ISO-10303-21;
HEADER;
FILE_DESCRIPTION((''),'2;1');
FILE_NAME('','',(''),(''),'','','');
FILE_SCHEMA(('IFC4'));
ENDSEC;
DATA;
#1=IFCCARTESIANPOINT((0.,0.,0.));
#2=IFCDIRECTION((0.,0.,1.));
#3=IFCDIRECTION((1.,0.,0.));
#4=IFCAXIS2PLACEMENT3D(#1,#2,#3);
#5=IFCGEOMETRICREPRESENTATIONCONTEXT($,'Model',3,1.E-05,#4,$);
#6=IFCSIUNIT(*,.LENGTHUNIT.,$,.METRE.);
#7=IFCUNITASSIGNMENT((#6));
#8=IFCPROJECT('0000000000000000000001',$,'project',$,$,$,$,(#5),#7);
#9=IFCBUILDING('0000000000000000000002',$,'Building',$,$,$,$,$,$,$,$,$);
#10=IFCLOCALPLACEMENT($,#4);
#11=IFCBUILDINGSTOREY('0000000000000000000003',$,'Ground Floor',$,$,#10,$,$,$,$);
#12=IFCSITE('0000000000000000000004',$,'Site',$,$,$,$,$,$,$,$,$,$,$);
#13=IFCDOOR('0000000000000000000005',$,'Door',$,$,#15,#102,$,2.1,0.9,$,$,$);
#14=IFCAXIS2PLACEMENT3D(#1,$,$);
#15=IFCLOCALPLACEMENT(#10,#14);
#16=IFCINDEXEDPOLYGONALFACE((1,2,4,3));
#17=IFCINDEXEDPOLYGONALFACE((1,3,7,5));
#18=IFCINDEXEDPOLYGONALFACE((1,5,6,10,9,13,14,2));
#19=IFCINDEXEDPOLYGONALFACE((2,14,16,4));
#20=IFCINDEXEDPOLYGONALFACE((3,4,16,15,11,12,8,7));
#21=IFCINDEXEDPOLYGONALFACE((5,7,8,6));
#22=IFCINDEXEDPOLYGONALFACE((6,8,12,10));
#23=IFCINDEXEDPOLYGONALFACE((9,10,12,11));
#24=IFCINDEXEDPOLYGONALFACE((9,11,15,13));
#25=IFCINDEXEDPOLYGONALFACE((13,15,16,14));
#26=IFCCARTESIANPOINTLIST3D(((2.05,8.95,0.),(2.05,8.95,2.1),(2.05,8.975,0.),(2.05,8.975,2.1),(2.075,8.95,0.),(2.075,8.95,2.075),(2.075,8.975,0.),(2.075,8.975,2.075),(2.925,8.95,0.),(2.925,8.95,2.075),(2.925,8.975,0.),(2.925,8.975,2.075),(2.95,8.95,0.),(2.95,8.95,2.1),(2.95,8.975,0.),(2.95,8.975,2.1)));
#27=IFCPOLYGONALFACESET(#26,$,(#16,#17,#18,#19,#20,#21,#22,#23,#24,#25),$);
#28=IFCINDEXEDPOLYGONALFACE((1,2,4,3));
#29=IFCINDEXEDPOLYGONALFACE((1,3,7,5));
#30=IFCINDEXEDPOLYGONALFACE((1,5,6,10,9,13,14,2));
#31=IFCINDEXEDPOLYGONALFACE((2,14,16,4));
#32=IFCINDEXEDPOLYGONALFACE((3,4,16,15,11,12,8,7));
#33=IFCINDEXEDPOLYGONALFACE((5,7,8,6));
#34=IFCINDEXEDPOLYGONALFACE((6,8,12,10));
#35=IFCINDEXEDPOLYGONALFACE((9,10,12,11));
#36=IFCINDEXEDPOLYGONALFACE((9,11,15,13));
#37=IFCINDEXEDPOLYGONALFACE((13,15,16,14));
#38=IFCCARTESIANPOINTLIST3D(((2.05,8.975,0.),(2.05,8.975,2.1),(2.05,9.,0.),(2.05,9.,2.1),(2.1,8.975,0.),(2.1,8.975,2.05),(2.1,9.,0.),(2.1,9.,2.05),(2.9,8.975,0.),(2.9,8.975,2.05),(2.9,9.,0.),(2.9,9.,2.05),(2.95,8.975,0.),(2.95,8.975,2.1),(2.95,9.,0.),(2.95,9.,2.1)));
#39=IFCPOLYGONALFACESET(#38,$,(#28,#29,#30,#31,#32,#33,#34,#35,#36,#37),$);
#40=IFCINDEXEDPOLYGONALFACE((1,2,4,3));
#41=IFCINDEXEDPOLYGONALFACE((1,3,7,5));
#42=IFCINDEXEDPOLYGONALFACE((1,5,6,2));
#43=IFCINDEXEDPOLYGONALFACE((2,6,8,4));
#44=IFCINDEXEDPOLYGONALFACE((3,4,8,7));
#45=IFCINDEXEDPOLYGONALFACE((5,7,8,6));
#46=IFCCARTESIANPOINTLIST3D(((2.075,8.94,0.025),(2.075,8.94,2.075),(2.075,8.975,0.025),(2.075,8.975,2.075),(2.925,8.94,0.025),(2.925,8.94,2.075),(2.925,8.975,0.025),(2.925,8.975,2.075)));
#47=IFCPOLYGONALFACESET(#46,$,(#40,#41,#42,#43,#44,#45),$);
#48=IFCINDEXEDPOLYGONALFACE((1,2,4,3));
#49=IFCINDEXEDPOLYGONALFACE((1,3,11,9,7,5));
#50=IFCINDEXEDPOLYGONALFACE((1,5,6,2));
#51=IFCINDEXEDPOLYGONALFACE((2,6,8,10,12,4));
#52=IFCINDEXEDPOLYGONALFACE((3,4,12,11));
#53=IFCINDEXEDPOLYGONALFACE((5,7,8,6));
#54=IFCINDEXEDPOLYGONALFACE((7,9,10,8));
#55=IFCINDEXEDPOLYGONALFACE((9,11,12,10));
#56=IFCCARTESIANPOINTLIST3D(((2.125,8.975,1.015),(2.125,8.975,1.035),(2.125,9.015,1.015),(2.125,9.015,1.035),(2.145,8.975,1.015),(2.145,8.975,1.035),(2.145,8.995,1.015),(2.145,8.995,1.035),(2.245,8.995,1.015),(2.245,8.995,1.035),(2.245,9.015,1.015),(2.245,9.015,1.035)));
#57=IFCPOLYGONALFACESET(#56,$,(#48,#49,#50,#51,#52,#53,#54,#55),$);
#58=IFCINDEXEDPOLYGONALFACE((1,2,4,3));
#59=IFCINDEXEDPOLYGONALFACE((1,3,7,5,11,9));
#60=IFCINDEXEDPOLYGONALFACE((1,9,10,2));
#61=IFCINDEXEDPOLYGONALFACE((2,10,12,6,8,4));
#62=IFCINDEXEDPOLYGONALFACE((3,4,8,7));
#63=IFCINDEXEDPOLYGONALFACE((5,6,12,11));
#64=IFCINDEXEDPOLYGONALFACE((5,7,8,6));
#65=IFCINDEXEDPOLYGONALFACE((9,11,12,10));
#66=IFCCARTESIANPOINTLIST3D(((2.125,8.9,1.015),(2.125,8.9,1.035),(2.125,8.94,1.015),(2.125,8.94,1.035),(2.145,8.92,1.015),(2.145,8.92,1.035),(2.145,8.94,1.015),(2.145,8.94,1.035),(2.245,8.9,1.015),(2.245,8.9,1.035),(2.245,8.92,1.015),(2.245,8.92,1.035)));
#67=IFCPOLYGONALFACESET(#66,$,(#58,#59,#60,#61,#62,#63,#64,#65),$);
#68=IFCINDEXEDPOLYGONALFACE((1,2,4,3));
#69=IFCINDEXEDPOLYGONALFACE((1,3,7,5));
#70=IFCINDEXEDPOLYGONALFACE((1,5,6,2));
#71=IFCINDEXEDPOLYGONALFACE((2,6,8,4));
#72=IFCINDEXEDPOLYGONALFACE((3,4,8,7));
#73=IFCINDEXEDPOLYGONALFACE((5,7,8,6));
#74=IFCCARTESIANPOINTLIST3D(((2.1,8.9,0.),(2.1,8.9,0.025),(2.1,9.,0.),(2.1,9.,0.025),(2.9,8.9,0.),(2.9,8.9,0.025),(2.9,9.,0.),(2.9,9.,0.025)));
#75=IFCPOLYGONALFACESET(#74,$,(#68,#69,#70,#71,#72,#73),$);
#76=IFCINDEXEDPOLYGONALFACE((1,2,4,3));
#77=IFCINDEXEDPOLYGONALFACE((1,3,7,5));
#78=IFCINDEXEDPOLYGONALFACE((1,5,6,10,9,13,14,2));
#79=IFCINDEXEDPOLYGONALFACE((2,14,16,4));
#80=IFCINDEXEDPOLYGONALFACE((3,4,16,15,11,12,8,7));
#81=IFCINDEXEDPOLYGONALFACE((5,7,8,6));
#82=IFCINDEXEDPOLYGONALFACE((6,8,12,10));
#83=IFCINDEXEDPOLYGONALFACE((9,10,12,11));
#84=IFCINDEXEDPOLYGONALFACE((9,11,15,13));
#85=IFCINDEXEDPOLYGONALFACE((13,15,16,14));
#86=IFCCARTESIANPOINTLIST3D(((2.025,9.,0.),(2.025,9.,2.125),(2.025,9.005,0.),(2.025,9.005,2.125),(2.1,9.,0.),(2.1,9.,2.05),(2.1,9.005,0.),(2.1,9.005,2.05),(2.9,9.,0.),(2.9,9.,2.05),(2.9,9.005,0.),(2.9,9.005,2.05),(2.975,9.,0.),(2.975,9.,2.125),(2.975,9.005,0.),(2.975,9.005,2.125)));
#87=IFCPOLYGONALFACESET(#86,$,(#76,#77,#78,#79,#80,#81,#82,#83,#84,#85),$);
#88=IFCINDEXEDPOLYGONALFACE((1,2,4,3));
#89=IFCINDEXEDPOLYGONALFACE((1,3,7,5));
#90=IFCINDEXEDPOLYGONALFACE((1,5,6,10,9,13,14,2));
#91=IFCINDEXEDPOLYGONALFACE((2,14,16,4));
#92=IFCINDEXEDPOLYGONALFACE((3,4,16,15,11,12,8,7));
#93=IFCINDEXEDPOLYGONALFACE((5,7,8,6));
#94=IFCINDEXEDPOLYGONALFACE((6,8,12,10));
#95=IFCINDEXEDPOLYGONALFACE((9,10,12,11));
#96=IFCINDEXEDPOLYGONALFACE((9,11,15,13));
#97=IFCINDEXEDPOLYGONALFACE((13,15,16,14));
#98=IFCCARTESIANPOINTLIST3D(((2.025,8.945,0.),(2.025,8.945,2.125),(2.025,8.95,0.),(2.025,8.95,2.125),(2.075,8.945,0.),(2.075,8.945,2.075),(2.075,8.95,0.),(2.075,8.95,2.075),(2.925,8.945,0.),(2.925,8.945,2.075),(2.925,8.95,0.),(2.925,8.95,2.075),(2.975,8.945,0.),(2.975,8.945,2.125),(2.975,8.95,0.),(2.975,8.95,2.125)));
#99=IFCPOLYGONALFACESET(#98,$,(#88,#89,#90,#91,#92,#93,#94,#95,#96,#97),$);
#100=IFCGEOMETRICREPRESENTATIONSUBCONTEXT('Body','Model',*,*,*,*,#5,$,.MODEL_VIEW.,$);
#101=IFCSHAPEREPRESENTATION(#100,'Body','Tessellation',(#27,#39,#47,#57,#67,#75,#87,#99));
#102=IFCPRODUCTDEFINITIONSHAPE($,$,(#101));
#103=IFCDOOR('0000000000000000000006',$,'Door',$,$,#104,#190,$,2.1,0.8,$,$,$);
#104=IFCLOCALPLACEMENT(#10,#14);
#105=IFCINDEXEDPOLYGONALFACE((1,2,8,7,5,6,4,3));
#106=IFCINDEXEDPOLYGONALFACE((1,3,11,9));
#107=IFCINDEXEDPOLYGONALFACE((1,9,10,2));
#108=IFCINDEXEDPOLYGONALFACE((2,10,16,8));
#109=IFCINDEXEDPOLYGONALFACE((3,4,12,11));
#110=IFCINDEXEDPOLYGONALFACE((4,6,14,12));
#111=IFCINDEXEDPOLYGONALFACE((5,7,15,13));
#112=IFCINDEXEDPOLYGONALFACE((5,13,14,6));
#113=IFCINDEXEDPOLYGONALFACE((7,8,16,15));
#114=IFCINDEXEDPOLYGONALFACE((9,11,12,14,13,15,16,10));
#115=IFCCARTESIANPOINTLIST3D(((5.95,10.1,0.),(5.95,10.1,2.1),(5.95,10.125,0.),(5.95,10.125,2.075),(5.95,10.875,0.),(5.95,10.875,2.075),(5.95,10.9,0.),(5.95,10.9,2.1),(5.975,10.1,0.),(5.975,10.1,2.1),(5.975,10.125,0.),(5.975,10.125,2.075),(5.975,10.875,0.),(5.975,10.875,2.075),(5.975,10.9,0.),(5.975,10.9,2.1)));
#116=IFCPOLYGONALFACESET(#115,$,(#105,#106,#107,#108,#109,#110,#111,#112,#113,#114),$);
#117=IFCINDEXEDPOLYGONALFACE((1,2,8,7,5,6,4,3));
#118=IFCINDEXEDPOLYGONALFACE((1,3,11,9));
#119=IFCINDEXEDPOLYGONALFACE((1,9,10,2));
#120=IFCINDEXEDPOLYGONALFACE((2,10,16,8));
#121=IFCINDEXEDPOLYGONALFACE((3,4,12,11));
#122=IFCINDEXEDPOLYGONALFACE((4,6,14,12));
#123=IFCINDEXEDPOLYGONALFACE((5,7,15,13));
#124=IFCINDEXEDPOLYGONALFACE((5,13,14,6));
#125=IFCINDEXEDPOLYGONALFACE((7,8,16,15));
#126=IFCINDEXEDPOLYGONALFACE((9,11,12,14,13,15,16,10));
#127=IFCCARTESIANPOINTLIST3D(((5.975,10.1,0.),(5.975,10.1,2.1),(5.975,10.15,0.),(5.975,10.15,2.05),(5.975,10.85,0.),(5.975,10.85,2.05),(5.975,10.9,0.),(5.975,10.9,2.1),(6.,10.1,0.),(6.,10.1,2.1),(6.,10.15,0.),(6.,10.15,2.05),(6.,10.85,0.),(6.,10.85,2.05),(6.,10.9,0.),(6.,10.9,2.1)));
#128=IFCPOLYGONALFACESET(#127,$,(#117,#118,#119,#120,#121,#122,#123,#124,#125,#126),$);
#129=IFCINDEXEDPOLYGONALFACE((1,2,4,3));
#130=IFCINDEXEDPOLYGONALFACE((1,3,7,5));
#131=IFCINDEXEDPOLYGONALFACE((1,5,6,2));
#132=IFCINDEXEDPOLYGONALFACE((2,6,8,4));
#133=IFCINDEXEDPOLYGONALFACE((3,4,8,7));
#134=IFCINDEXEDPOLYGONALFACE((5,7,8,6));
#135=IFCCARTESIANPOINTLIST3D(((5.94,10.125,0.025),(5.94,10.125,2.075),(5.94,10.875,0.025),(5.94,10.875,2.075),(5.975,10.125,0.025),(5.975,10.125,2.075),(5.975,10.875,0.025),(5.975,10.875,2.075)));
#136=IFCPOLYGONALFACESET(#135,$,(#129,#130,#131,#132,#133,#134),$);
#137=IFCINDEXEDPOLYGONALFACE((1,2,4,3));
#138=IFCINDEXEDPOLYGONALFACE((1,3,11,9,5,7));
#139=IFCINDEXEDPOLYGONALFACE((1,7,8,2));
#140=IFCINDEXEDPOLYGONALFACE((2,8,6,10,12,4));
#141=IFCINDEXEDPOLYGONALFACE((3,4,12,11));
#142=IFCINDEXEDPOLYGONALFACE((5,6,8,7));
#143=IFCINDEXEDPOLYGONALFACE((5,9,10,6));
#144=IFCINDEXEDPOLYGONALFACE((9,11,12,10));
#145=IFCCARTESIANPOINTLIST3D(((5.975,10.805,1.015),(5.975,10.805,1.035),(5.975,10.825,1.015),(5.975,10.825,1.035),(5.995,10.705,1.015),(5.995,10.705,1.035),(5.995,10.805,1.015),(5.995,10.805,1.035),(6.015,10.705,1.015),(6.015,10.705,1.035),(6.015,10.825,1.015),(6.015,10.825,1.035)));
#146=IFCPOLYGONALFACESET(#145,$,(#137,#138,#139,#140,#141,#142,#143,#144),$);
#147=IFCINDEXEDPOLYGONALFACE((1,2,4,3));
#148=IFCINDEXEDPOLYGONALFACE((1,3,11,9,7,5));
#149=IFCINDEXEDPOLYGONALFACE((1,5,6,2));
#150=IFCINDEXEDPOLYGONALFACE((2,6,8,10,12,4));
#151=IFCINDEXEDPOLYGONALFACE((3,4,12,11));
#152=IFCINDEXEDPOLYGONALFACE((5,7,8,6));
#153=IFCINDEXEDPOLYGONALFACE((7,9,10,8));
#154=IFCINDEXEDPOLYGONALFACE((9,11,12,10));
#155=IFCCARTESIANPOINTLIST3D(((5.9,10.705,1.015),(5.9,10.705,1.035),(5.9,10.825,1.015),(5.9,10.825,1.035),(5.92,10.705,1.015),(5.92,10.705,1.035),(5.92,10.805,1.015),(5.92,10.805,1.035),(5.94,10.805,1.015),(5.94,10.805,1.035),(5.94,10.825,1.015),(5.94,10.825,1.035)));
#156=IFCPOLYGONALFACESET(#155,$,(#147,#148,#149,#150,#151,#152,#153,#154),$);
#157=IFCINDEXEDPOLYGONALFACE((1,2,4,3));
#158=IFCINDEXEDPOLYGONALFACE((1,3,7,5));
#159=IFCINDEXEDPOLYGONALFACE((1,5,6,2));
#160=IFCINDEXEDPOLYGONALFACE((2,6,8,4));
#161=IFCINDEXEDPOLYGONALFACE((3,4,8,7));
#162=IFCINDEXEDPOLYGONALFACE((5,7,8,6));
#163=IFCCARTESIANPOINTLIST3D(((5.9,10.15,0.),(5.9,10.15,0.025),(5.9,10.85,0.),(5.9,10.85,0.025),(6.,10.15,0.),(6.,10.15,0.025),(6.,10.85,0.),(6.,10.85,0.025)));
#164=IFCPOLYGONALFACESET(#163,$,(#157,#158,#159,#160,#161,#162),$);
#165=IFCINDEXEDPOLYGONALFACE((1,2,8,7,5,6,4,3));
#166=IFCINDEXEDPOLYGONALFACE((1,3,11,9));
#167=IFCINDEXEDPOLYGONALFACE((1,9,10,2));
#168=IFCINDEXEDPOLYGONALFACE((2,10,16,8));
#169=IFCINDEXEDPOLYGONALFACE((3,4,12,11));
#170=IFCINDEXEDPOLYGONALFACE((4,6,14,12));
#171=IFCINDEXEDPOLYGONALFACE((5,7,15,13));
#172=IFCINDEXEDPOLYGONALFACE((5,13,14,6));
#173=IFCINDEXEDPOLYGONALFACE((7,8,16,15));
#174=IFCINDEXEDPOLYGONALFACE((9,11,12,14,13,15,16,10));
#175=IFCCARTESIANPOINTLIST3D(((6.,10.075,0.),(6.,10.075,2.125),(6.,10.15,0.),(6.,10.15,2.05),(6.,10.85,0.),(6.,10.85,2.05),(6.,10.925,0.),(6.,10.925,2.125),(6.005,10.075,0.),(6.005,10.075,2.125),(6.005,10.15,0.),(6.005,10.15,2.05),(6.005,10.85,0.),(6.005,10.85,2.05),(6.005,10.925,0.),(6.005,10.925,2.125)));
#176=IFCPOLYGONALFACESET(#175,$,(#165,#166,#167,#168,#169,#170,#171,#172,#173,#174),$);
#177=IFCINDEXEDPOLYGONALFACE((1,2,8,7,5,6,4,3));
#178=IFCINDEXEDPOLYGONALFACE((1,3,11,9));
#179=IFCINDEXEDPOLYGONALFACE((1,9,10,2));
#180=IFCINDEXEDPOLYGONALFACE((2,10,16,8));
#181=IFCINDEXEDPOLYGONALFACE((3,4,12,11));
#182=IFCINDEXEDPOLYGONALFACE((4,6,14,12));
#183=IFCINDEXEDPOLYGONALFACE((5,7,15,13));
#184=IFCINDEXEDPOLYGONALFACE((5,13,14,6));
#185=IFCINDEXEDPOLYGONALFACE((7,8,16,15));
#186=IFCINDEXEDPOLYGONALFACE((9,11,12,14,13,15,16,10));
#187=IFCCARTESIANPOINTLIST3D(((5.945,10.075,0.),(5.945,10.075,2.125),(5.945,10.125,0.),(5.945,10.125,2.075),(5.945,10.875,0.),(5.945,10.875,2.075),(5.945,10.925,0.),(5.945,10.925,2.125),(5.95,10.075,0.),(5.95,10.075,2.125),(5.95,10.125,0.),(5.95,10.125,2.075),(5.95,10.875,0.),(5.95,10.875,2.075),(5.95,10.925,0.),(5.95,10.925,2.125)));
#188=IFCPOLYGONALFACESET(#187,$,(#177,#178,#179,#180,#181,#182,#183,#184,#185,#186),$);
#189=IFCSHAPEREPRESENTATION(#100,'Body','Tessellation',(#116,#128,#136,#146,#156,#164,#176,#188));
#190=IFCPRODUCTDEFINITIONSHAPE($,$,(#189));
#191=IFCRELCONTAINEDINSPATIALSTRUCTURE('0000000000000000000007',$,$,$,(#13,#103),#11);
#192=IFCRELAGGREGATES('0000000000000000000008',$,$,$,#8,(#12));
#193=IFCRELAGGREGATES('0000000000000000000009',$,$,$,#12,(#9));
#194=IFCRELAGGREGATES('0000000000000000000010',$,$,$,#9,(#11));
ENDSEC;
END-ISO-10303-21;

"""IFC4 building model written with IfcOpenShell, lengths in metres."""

from ifc_helpers import new_model, si_unit, frame, origin_with_axes, place, context, subcontext, project, spatial, line, indexed_curve, outline, extrude, element, save


model = new_model("IFC4")

# Units and contexts
model_context = context("Model", 3, precision=1e-05, world=origin_with_axes())
body_context = subcontext(model_context, "Body", "Model", "MODEL_VIEW")
ifc_project = project(units=[si_unit("LENGTHUNIT", "METRE")], contexts=[model_context])

# Site, building, storey
site = spatial("IfcSite", under=ifc_project, Name="Site")
building = spatial("IfcBuilding", under=site, Name="Building")
storey_placement = place(None, origin_with_axes())
storey = spatial("IfcBuildingStorey", under=building, at=storey_placement, Name="Ground Floor")

# Doors
door_1_placement = place(storey_placement, frame((2.95, 9.0, 0.0), z_axis=(0.0, 0.0, 1.0), x_axis=(-1.0, 0.0, 0.0)))
element("IfcDoor", 1, at=door_1_placement, inside=storey, Name="Door", OverallHeight=2.1, OverallWidth=0.9, context=body_context, shape_type="SweptSolid", body=[
    extrude(outline(indexed_curve([(0.0, 0.0), (0.0, 2.1), (0.9, 2.1), (0.9, 0.0), (0.875, 0.0), (0.875, 2.075), (0.025, 2.075), (0.025, 0.0)], segments=[line(1, 2, 3, 4, 5, 6, 7, 8, 1)])), frame((0.0, 0.025, 0.0), z_axis=(0.0, -1.0, 0.0), x_axis=(1.0, 0.0, 0.0)), (0.0, 0.0, -1.0), 0.025),
    extrude(outline(indexed_curve([(0.0, 0.0), (0.0, 2.1), (0.9, 2.1), (0.9, 0.0), (0.85, 0.0), (0.85, 2.05), (0.05, 2.05), (0.05, 0.0)], segments=[line(1, 2, 3, 4, 5, 6, 7, 8, 1)])), frame((0.0, 0.0, 0.0), z_axis=(0.0, -1.0, 0.0), x_axis=(1.0, 0.0, 0.0)), (0.0, 0.0, -1.0), 0.025),
    extrude(outline(indexed_curve([(0.0, 0.0), (0.85, 0.0), (0.85, 0.035), (0.0, 0.035)], segments=[line(1, 2, 3, 4, 1)])), frame((0.025, 0.025, 0.025), z_axis=(0.0, 0.0, 1.0), x_axis=(1.0, 0.0, 0.0)), (0.0, 0.0, 1.0), 2.05),
    extrude(outline(indexed_curve([(0.0, 0.0), (0.0, -0.04), (-0.12, -0.04), (-0.12, -0.02), (-0.02, -0.02), (-0.02, 0.0)], segments=[line(1, 2, 3, 4, 5, 6, 1)])), frame((0.825, 0.025, 1.015), z_axis=(0.0, 0.0, 1.0), x_axis=(1.0, 0.0, 0.0)), (0.0, 0.0, 1.0), 0.02),
    extrude(outline(indexed_curve([(0.0, 0.0), (0.0, 0.04), (-0.12, 0.04), (-0.12, 0.02), (-0.02, 0.02), (-0.02, 0.0)], segments=[line(1, 2, 3, 4, 5, 6, 1)])), frame((0.825, 0.06, 1.015), z_axis=(0.0, 0.0, 1.0), x_axis=(1.0, 0.0, 0.0)), (0.0, 0.0, 1.0), 0.02),
    extrude(outline(indexed_curve([(0.0, 0.0), (0.8, 0.0), (0.8, 0.1), (0.0, 0.1)], segments=[line(1, 2, 3, 4, 1)])), frame((0.05, 0.0, 0.0), z_axis=(0.0, 0.0, 1.0), x_axis=(1.0, 0.0, 0.0)), (0.0, 0.0, 1.0), 0.025),
    extrude(outline(indexed_curve([(0.0, 0.0), (0.0, 2.125), (0.95, 2.125), (0.95, 0.0), (0.875, 0.0), (0.875, 2.05), (0.075, 2.05), (0.075, 0.0)], segments=[line(1, 2, 3, 4, 5, 6, 7, 8, 1)])), frame((-0.025, -0.005, 0.0), z_axis=(0.0, -1.0, 0.0), x_axis=(1.0, 0.0, 0.0)), (0.0, 0.0, -1.0), 0.005),
    extrude(outline(indexed_curve([(0.0, 0.0), (0.0, 2.125), (0.95, 2.125), (0.95, 0.0), (0.9, 0.0), (0.9, 2.075), (0.05, 2.075), (0.05, 0.0)], segments=[line(1, 2, 3, 4, 5, 6, 7, 8, 1)])), frame((-0.025, 0.05, 0.0), z_axis=(0.0, -1.0, 0.0), x_axis=(1.0, 0.0, 0.0)), (0.0, 0.0, -1.0), 0.005),
])
door_2_placement = place(storey_placement, frame((6.0, 10.1, 0.0), z_axis=(0.0, 0.0, 1.0), x_axis=(0.0, 1.0, 0.0)))
element("IfcDoor", 2, at=door_2_placement, inside=storey, Name="Door", OverallHeight=2.1, OverallWidth=0.8, context=body_context, shape_type="SweptSolid", body=[
    extrude(outline(indexed_curve([(0.0, 0.0), (0.0, 2.1), (0.8, 2.1), (0.8, 0.0), (0.775, 0.0), (0.775, 2.075), (0.025, 2.075), (0.025, 0.0)], segments=[line(1, 2, 3, 4, 5, 6, 7, 8, 1)])), frame((0.0, 0.025, 0.0), z_axis=(0.0, -1.0, 0.0), x_axis=(1.0, 0.0, 0.0)), (0.0, 0.0, -1.0), 0.025),
    extrude(outline(indexed_curve([(0.0, 0.0), (0.0, 2.1), (0.8, 2.1), (0.8, 0.0), (0.75, 0.0), (0.75, 2.05), (0.05, 2.05), (0.05, 0.0)], segments=[line(1, 2, 3, 4, 5, 6, 7, 8, 1)])), frame((0.0, 0.0, 0.0), z_axis=(0.0, -1.0, 0.0), x_axis=(1.0, 0.0, 0.0)), (0.0, 0.0, -1.0), 0.025),
    extrude(outline(indexed_curve([(0.0, 0.0), (0.75, 0.0), (0.75, 0.035), (0.0, 0.035)], segments=[line(1, 2, 3, 4, 1)])), frame((0.025, 0.025, 0.025), z_axis=(0.0, 0.0, 1.0), x_axis=(1.0, 0.0, 0.0)), (0.0, 0.0, 1.0), 2.05),
    extrude(outline(indexed_curve([(0.0, 0.0), (0.0, -0.04), (-0.12, -0.04), (-0.12, -0.02), (-0.02, -0.02), (-0.02, 0.0)], segments=[line(1, 2, 3, 4, 5, 6, 1)])), frame((0.725, 0.025, 1.015), z_axis=(0.0, 0.0, 1.0), x_axis=(1.0, 0.0, 0.0)), (0.0, 0.0, 1.0), 0.02),
    extrude(outline(indexed_curve([(0.0, 0.0), (0.0, 0.04), (-0.12, 0.04), (-0.12, 0.02), (-0.02, 0.02), (-0.02, 0.0)], segments=[line(1, 2, 3, 4, 5, 6, 1)])), frame((0.725, 0.06, 1.015), z_axis=(0.0, 0.0, 1.0), x_axis=(1.0, 0.0, 0.0)), (0.0, 0.0, 1.0), 0.02),
    extrude(outline(indexed_curve([(0.0, 0.0), (0.7, 0.0), (0.7, 0.1), (0.0, 0.1)], segments=[line(1, 2, 3, 4, 1)])), frame((0.05, 0.0, 0.0), z_axis=(0.0, 0.0, 1.0), x_axis=(1.0, 0.0, 0.0)), (0.0, 0.0, 1.0), 0.025),
    extrude(outline(indexed_curve([(0.0, 0.0), (0.0, 2.125), (0.85, 2.125), (0.85, 0.0), (0.775, 0.0), (0.775, 2.05), (0.075, 2.05), (0.075, 0.0)], segments=[line(1, 2, 3, 4, 5, 6, 7, 8, 1)])), frame((-0.025, -0.005, 0.0), z_axis=(0.0, -1.0, 0.0), x_axis=(1.0, 0.0, 0.0)), (0.0, 0.0, -1.0), 0.005),
    extrude(outline(indexed_curve([(0.0, 0.0), (0.0, 2.125), (0.85, 2.125), (0.85, 0.0), (0.8, 0.0), (0.8, 2.075), (0.05, 2.075), (0.05, 0.0)], segments=[line(1, 2, 3, 4, 5, 6, 7, 8, 1)])), frame((-0.025, 0.05, 0.0), z_axis=(0.0, -1.0, 0.0), x_axis=(1.0, 0.0, 0.0)), (0.0, 0.0, -1.0), 0.005),
])

save(model, "model.ifc")
